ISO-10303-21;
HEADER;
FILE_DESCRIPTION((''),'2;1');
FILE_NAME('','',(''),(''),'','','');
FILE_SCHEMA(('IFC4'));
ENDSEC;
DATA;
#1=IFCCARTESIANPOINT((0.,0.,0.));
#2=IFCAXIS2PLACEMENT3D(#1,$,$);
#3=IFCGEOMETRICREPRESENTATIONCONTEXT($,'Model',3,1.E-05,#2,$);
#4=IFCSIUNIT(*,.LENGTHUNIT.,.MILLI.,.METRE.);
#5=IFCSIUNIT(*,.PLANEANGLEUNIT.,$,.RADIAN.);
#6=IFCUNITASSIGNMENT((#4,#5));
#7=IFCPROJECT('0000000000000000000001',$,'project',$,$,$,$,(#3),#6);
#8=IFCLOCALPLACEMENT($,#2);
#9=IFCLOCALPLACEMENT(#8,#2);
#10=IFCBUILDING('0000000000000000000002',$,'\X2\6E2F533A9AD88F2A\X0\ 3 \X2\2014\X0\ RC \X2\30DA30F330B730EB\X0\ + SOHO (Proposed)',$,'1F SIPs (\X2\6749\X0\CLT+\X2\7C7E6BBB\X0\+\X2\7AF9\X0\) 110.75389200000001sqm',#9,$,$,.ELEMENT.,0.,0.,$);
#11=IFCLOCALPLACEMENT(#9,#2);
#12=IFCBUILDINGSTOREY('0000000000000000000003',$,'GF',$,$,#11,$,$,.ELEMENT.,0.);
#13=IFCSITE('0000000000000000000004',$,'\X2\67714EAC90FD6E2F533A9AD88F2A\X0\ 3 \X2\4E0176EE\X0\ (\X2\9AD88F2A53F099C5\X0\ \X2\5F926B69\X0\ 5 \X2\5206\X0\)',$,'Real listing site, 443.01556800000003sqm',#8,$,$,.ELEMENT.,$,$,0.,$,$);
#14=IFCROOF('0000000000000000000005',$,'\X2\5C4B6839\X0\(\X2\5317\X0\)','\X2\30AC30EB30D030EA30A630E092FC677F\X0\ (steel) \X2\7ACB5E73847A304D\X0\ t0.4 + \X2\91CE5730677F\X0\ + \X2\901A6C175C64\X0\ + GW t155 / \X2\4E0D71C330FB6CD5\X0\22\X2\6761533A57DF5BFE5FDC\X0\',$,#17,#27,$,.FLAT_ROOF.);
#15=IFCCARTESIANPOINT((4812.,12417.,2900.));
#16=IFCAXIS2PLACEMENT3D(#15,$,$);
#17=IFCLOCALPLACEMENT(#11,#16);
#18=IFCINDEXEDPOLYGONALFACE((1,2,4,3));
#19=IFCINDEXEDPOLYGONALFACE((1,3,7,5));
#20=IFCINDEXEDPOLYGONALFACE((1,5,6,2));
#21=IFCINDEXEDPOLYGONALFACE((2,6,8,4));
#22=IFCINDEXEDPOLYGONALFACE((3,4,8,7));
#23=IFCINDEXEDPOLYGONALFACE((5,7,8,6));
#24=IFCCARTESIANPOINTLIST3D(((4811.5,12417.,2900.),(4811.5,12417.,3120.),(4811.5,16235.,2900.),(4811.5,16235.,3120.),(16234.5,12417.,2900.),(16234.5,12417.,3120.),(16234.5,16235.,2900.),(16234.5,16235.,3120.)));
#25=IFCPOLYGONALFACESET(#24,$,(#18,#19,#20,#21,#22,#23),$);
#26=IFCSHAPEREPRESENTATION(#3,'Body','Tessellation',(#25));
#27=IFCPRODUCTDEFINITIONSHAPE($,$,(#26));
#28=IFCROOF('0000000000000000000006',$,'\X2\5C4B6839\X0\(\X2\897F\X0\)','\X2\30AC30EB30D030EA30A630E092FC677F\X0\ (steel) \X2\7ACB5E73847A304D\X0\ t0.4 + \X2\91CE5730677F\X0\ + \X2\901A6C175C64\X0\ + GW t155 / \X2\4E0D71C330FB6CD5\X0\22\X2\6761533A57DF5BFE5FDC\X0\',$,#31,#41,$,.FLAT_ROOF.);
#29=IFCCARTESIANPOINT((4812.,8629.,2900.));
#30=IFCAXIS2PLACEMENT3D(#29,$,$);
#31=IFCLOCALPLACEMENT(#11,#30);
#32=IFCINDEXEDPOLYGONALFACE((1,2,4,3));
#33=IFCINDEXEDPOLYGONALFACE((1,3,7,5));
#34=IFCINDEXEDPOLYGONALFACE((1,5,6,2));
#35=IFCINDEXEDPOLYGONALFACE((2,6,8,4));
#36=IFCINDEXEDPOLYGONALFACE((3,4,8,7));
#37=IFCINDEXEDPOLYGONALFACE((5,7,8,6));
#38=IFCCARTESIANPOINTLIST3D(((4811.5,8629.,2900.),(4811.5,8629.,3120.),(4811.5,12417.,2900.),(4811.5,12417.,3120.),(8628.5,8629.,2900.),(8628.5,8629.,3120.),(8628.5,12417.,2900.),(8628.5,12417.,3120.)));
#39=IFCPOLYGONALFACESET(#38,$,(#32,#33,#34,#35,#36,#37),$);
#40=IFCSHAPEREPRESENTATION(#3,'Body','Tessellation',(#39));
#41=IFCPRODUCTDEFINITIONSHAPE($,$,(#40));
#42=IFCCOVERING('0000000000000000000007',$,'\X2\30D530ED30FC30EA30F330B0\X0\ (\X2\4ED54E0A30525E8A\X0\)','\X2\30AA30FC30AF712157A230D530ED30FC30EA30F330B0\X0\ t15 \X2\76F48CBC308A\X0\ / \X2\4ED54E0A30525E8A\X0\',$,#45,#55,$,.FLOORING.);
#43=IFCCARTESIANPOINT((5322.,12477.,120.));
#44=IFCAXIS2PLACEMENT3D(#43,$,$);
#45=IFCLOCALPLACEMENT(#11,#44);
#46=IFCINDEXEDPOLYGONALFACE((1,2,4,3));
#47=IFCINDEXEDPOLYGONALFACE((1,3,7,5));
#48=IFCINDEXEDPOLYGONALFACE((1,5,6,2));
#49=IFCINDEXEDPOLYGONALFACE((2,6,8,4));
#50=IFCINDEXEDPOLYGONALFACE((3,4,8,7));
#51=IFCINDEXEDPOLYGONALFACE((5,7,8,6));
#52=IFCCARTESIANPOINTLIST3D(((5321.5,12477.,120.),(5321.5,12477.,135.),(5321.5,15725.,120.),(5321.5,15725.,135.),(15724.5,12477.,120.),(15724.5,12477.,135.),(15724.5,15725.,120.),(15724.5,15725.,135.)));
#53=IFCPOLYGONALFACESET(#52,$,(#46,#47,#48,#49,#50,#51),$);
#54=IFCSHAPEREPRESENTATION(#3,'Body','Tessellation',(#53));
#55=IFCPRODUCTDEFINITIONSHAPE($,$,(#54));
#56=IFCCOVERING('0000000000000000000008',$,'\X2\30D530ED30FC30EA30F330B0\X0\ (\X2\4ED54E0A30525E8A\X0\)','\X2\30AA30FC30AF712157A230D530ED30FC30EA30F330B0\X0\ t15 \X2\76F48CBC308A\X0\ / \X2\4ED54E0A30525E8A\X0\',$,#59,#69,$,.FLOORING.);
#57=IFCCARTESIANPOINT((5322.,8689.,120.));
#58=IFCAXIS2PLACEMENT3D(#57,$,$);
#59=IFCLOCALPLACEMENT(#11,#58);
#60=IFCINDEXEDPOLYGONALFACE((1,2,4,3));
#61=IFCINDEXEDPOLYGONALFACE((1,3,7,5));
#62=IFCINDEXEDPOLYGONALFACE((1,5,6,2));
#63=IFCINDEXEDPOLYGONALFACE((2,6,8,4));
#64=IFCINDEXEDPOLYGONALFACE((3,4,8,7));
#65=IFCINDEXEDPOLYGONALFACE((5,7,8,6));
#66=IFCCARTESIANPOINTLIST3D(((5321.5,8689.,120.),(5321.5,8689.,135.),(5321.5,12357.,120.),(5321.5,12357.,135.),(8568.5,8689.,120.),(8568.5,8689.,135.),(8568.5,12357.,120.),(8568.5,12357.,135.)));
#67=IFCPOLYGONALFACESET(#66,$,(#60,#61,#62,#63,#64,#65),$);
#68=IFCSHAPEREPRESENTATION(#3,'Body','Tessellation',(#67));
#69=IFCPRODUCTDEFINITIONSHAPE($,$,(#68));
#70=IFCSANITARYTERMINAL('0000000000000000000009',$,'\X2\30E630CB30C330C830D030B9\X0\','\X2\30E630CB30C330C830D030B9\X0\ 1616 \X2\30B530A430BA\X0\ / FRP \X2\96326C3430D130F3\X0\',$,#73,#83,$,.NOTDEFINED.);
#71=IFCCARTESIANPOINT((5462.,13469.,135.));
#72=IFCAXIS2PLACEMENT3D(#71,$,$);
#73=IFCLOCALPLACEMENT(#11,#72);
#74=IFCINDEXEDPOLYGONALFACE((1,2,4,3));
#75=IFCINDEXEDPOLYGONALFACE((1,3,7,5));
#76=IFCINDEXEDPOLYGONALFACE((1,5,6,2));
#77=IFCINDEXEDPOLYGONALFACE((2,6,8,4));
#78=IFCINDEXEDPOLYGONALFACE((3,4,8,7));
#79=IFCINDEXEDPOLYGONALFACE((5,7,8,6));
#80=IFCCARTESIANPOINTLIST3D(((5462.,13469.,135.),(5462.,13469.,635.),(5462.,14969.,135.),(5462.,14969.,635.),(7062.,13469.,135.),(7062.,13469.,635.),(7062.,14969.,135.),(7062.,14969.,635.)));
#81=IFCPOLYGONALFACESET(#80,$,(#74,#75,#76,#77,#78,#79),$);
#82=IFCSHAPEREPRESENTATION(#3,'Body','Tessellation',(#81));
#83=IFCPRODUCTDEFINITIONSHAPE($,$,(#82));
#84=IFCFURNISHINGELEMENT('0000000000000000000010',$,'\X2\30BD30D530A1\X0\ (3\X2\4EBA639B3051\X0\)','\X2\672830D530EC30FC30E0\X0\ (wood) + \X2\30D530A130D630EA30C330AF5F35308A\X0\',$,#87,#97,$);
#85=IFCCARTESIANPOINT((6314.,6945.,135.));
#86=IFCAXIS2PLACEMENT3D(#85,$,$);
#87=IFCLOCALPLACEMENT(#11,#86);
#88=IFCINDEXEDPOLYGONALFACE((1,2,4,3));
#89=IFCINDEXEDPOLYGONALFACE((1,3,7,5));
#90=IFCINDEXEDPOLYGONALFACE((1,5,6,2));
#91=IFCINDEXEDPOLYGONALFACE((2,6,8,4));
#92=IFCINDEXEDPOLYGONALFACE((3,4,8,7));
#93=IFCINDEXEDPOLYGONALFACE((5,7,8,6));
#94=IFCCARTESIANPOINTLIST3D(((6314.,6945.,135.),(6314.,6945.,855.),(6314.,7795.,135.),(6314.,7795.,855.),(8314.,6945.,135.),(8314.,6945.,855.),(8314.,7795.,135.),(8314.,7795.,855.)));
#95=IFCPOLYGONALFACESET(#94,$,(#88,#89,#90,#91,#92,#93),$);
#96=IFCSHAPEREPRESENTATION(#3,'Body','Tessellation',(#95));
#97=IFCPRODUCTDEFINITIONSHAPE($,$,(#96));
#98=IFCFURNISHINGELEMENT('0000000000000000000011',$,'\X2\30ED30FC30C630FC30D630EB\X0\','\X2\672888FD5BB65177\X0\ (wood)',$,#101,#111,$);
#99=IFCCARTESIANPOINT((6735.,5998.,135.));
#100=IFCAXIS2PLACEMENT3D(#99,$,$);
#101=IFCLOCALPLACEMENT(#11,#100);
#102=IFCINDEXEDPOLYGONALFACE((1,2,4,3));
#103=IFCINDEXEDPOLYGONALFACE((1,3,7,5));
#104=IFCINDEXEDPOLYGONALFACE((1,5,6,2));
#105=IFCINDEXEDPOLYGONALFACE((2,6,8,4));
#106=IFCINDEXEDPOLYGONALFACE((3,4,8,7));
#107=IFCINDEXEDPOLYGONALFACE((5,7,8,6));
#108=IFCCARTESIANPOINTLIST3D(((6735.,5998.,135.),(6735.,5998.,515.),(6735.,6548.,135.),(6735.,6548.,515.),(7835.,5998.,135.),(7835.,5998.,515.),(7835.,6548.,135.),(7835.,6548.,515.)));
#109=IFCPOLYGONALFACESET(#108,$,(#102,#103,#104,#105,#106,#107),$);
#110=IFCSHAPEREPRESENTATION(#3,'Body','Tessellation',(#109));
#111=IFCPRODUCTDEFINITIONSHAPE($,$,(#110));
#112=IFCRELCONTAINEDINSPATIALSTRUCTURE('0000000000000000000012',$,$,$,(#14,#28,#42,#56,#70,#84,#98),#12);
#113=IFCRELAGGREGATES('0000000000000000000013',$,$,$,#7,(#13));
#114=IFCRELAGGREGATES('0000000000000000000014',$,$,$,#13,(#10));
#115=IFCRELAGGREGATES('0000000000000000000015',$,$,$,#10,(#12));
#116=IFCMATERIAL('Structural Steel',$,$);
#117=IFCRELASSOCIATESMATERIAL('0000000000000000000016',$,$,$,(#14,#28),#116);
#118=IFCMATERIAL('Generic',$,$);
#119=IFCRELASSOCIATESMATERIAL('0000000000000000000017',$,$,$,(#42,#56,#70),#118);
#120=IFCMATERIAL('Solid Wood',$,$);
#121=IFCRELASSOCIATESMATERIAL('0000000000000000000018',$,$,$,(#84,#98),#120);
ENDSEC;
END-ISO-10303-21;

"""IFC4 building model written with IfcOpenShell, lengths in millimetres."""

from ifc_helpers import new_model, si_unit, frame, frame_2d, origin, place, context, project, spatial, rectangle, extrude, material, element, save


model = new_model("IFC4")

# Units and contexts
model_context = context("Model", 3, precision=1e-05, world=origin())
ifc_project = project(units=[si_unit("LENGTHUNIT", "METRE", prefix="MILLI"), si_unit("PLANEANGLEUNIT", "RADIAN")], contexts=[model_context])

# Site, building, storey
site_placement = place(None, origin())
site = spatial("IfcSite", under=ifc_project, at=site_placement, Name="東京都港区高輪 3 丁目 (高輪台駅 徒歩 5 分)", ObjectType="Real listing site, 443.01556800000003sqm", CompositionType="ELEMENT", RefElevation=0.0)
building_placement = place(site_placement, origin())
building = spatial("IfcBuilding", under=site, at=building_placement, Name="港区高輪 3 — RC ペンシル + SOHO (Proposed)", ObjectType="1F SIPs (杉CLT+籾殻+竹) 110.75389200000001sqm", CompositionType="ELEMENT", ElevationOfRefHeight=0.0, ElevationOfTerrain=0.0)
storey_placement = place(building_placement, origin())
storey = spatial("IfcBuildingStorey", under=building, at=storey_placement, Name="GF", CompositionType="ELEMENT", Elevation=0.0)

# Shared definitions
ifc_material_1 = material(Name="Solid Wood")

# Roofs
ifc_material_2 = material(Name="Structural Steel")
roof_1_placement = place(storey_placement, frame((4812.0, 12417.0, 2900.0)))
element("IfcRoof", 1, at=roof_1_placement, inside=storey, material=ifc_material_2, Name="屋根(北)", Description="ガルバリウム鋼板 (steel) 立平葺き t0.4 + 野地板 + 通気層 + GW t155 / 不燃・法22条区域対応", PredefinedType="FLAT_ROOF", context=model_context, shape_type="SweptSolid", body=[
    extrude(rectangle(XDim=11423.0, YDim=3818.0, at=frame_2d((5711.0, 1909.0))), frame((4812.0, 12417.0, 2900.0)), (0.0, 0.0, 1.0), 220.0),
])
roof_2_placement = place(storey_placement, frame((4812.0, 8629.0, 2900.0)))
element("IfcRoof", 2, at=roof_2_placement, inside=storey, material=ifc_material_2, Name="屋根(西)", Description="ガルバリウム鋼板 (steel) 立平葺き t0.4 + 野地板 + 通気層 + GW t155 / 不燃・法22条区域対応", PredefinedType="FLAT_ROOF", context=model_context, shape_type="SweptSolid", body=[
    extrude(rectangle(XDim=3817.0, YDim=3788.0, at=frame_2d((1908.0, 1894.0))), frame((4812.0, 8629.0, 2900.0)), (0.0, 0.0, 1.0), 220.0),
])

# Coverings
ifc_material_3 = material(Name="Generic")
covering_1_placement = place(storey_placement, frame((5322.0, 12477.0, 120.0)))
element("IfcCovering", 3, at=covering_1_placement, inside=storey, material=ifc_material_3, Name="フローリング (仕上げ床)", Description="オーク無垢フローリング t15 直貼り / 仕上げ床", PredefinedType="FLOORING", context=model_context, shape_type="SweptSolid", body=[
    extrude(rectangle(XDim=10403.0, YDim=3248.0, at=frame_2d((5201.0, 1624.0))), frame((5322.0, 12477.0, 120.0)), (0.0, 0.0, 1.0), 15.0),
])
covering_2_placement = place(storey_placement, frame((5322.0, 8689.0, 120.0)))
element("IfcCovering", 4, at=covering_2_placement, inside=storey, material=ifc_material_3, Name="フローリング (仕上げ床)", Description="オーク無垢フローリング t15 直貼り / 仕上げ床", PredefinedType="FLOORING", context=model_context, shape_type="SweptSolid", body=[
    extrude(rectangle(XDim=3247.0, YDim=3668.0, at=frame_2d((1623.0, 1834.0))), frame((5322.0, 8689.0, 120.0)), (0.0, 0.0, 1.0), 15.0),
])

# Sanitary terminal
sanitary_terminal_placement = place(storey_placement, frame((5462.0, 13469.0, 135.0)))
element("IfcSanitaryTerminal", 5, at=sanitary_terminal_placement, inside=storey, material=ifc_material_3, Name="ユニットバス", Description="ユニットバス 1616 サイズ / FRP 防水パン", PredefinedType="NOTDEFINED", context=model_context, shape_type="SweptSolid", body=[
    extrude(rectangle(XDim=1600.0, YDim=1500.0, at=frame_2d((800.0, 750.0))), frame((5462.0, 13469.0, 135.0)), (0.0, 0.0, 1.0), 500.0),
])

# Furnishing elements
furnishing_1_placement = place(storey_placement, frame((6314.0, 6945.0, 135.0)))
element("IfcFurnishingElement", 6, at=furnishing_1_placement, inside=storey, material=ifc_material_1, Name="ソファ (3人掛け)", Description="木フレーム (wood) + ファブリック張り", context=model_context, shape_type="SweptSolid", body=[
    extrude(rectangle(XDim=2000.0, YDim=850.0, at=frame_2d((1000.0, 425.0))), frame((6314.0, 6945.0, 135.0)), (0.0, 0.0, 1.0), 720.0),
])
furnishing_2_placement = place(storey_placement, frame((6735.0, 5998.0, 135.0)))
element("IfcFurnishingElement", 7, at=furnishing_2_placement, inside=storey, material=ifc_material_1, Name="ローテーブル", Description="木製家具 (wood)", context=model_context, shape_type="SweptSolid", body=[
    extrude(rectangle(XDim=1100.0, YDim=550.0, at=frame_2d((550.0, 275.0))), frame((6735.0, 5998.0, 135.0)), (0.0, 0.0, 1.0), 380.0),
])

save(model, "model.ifc")
